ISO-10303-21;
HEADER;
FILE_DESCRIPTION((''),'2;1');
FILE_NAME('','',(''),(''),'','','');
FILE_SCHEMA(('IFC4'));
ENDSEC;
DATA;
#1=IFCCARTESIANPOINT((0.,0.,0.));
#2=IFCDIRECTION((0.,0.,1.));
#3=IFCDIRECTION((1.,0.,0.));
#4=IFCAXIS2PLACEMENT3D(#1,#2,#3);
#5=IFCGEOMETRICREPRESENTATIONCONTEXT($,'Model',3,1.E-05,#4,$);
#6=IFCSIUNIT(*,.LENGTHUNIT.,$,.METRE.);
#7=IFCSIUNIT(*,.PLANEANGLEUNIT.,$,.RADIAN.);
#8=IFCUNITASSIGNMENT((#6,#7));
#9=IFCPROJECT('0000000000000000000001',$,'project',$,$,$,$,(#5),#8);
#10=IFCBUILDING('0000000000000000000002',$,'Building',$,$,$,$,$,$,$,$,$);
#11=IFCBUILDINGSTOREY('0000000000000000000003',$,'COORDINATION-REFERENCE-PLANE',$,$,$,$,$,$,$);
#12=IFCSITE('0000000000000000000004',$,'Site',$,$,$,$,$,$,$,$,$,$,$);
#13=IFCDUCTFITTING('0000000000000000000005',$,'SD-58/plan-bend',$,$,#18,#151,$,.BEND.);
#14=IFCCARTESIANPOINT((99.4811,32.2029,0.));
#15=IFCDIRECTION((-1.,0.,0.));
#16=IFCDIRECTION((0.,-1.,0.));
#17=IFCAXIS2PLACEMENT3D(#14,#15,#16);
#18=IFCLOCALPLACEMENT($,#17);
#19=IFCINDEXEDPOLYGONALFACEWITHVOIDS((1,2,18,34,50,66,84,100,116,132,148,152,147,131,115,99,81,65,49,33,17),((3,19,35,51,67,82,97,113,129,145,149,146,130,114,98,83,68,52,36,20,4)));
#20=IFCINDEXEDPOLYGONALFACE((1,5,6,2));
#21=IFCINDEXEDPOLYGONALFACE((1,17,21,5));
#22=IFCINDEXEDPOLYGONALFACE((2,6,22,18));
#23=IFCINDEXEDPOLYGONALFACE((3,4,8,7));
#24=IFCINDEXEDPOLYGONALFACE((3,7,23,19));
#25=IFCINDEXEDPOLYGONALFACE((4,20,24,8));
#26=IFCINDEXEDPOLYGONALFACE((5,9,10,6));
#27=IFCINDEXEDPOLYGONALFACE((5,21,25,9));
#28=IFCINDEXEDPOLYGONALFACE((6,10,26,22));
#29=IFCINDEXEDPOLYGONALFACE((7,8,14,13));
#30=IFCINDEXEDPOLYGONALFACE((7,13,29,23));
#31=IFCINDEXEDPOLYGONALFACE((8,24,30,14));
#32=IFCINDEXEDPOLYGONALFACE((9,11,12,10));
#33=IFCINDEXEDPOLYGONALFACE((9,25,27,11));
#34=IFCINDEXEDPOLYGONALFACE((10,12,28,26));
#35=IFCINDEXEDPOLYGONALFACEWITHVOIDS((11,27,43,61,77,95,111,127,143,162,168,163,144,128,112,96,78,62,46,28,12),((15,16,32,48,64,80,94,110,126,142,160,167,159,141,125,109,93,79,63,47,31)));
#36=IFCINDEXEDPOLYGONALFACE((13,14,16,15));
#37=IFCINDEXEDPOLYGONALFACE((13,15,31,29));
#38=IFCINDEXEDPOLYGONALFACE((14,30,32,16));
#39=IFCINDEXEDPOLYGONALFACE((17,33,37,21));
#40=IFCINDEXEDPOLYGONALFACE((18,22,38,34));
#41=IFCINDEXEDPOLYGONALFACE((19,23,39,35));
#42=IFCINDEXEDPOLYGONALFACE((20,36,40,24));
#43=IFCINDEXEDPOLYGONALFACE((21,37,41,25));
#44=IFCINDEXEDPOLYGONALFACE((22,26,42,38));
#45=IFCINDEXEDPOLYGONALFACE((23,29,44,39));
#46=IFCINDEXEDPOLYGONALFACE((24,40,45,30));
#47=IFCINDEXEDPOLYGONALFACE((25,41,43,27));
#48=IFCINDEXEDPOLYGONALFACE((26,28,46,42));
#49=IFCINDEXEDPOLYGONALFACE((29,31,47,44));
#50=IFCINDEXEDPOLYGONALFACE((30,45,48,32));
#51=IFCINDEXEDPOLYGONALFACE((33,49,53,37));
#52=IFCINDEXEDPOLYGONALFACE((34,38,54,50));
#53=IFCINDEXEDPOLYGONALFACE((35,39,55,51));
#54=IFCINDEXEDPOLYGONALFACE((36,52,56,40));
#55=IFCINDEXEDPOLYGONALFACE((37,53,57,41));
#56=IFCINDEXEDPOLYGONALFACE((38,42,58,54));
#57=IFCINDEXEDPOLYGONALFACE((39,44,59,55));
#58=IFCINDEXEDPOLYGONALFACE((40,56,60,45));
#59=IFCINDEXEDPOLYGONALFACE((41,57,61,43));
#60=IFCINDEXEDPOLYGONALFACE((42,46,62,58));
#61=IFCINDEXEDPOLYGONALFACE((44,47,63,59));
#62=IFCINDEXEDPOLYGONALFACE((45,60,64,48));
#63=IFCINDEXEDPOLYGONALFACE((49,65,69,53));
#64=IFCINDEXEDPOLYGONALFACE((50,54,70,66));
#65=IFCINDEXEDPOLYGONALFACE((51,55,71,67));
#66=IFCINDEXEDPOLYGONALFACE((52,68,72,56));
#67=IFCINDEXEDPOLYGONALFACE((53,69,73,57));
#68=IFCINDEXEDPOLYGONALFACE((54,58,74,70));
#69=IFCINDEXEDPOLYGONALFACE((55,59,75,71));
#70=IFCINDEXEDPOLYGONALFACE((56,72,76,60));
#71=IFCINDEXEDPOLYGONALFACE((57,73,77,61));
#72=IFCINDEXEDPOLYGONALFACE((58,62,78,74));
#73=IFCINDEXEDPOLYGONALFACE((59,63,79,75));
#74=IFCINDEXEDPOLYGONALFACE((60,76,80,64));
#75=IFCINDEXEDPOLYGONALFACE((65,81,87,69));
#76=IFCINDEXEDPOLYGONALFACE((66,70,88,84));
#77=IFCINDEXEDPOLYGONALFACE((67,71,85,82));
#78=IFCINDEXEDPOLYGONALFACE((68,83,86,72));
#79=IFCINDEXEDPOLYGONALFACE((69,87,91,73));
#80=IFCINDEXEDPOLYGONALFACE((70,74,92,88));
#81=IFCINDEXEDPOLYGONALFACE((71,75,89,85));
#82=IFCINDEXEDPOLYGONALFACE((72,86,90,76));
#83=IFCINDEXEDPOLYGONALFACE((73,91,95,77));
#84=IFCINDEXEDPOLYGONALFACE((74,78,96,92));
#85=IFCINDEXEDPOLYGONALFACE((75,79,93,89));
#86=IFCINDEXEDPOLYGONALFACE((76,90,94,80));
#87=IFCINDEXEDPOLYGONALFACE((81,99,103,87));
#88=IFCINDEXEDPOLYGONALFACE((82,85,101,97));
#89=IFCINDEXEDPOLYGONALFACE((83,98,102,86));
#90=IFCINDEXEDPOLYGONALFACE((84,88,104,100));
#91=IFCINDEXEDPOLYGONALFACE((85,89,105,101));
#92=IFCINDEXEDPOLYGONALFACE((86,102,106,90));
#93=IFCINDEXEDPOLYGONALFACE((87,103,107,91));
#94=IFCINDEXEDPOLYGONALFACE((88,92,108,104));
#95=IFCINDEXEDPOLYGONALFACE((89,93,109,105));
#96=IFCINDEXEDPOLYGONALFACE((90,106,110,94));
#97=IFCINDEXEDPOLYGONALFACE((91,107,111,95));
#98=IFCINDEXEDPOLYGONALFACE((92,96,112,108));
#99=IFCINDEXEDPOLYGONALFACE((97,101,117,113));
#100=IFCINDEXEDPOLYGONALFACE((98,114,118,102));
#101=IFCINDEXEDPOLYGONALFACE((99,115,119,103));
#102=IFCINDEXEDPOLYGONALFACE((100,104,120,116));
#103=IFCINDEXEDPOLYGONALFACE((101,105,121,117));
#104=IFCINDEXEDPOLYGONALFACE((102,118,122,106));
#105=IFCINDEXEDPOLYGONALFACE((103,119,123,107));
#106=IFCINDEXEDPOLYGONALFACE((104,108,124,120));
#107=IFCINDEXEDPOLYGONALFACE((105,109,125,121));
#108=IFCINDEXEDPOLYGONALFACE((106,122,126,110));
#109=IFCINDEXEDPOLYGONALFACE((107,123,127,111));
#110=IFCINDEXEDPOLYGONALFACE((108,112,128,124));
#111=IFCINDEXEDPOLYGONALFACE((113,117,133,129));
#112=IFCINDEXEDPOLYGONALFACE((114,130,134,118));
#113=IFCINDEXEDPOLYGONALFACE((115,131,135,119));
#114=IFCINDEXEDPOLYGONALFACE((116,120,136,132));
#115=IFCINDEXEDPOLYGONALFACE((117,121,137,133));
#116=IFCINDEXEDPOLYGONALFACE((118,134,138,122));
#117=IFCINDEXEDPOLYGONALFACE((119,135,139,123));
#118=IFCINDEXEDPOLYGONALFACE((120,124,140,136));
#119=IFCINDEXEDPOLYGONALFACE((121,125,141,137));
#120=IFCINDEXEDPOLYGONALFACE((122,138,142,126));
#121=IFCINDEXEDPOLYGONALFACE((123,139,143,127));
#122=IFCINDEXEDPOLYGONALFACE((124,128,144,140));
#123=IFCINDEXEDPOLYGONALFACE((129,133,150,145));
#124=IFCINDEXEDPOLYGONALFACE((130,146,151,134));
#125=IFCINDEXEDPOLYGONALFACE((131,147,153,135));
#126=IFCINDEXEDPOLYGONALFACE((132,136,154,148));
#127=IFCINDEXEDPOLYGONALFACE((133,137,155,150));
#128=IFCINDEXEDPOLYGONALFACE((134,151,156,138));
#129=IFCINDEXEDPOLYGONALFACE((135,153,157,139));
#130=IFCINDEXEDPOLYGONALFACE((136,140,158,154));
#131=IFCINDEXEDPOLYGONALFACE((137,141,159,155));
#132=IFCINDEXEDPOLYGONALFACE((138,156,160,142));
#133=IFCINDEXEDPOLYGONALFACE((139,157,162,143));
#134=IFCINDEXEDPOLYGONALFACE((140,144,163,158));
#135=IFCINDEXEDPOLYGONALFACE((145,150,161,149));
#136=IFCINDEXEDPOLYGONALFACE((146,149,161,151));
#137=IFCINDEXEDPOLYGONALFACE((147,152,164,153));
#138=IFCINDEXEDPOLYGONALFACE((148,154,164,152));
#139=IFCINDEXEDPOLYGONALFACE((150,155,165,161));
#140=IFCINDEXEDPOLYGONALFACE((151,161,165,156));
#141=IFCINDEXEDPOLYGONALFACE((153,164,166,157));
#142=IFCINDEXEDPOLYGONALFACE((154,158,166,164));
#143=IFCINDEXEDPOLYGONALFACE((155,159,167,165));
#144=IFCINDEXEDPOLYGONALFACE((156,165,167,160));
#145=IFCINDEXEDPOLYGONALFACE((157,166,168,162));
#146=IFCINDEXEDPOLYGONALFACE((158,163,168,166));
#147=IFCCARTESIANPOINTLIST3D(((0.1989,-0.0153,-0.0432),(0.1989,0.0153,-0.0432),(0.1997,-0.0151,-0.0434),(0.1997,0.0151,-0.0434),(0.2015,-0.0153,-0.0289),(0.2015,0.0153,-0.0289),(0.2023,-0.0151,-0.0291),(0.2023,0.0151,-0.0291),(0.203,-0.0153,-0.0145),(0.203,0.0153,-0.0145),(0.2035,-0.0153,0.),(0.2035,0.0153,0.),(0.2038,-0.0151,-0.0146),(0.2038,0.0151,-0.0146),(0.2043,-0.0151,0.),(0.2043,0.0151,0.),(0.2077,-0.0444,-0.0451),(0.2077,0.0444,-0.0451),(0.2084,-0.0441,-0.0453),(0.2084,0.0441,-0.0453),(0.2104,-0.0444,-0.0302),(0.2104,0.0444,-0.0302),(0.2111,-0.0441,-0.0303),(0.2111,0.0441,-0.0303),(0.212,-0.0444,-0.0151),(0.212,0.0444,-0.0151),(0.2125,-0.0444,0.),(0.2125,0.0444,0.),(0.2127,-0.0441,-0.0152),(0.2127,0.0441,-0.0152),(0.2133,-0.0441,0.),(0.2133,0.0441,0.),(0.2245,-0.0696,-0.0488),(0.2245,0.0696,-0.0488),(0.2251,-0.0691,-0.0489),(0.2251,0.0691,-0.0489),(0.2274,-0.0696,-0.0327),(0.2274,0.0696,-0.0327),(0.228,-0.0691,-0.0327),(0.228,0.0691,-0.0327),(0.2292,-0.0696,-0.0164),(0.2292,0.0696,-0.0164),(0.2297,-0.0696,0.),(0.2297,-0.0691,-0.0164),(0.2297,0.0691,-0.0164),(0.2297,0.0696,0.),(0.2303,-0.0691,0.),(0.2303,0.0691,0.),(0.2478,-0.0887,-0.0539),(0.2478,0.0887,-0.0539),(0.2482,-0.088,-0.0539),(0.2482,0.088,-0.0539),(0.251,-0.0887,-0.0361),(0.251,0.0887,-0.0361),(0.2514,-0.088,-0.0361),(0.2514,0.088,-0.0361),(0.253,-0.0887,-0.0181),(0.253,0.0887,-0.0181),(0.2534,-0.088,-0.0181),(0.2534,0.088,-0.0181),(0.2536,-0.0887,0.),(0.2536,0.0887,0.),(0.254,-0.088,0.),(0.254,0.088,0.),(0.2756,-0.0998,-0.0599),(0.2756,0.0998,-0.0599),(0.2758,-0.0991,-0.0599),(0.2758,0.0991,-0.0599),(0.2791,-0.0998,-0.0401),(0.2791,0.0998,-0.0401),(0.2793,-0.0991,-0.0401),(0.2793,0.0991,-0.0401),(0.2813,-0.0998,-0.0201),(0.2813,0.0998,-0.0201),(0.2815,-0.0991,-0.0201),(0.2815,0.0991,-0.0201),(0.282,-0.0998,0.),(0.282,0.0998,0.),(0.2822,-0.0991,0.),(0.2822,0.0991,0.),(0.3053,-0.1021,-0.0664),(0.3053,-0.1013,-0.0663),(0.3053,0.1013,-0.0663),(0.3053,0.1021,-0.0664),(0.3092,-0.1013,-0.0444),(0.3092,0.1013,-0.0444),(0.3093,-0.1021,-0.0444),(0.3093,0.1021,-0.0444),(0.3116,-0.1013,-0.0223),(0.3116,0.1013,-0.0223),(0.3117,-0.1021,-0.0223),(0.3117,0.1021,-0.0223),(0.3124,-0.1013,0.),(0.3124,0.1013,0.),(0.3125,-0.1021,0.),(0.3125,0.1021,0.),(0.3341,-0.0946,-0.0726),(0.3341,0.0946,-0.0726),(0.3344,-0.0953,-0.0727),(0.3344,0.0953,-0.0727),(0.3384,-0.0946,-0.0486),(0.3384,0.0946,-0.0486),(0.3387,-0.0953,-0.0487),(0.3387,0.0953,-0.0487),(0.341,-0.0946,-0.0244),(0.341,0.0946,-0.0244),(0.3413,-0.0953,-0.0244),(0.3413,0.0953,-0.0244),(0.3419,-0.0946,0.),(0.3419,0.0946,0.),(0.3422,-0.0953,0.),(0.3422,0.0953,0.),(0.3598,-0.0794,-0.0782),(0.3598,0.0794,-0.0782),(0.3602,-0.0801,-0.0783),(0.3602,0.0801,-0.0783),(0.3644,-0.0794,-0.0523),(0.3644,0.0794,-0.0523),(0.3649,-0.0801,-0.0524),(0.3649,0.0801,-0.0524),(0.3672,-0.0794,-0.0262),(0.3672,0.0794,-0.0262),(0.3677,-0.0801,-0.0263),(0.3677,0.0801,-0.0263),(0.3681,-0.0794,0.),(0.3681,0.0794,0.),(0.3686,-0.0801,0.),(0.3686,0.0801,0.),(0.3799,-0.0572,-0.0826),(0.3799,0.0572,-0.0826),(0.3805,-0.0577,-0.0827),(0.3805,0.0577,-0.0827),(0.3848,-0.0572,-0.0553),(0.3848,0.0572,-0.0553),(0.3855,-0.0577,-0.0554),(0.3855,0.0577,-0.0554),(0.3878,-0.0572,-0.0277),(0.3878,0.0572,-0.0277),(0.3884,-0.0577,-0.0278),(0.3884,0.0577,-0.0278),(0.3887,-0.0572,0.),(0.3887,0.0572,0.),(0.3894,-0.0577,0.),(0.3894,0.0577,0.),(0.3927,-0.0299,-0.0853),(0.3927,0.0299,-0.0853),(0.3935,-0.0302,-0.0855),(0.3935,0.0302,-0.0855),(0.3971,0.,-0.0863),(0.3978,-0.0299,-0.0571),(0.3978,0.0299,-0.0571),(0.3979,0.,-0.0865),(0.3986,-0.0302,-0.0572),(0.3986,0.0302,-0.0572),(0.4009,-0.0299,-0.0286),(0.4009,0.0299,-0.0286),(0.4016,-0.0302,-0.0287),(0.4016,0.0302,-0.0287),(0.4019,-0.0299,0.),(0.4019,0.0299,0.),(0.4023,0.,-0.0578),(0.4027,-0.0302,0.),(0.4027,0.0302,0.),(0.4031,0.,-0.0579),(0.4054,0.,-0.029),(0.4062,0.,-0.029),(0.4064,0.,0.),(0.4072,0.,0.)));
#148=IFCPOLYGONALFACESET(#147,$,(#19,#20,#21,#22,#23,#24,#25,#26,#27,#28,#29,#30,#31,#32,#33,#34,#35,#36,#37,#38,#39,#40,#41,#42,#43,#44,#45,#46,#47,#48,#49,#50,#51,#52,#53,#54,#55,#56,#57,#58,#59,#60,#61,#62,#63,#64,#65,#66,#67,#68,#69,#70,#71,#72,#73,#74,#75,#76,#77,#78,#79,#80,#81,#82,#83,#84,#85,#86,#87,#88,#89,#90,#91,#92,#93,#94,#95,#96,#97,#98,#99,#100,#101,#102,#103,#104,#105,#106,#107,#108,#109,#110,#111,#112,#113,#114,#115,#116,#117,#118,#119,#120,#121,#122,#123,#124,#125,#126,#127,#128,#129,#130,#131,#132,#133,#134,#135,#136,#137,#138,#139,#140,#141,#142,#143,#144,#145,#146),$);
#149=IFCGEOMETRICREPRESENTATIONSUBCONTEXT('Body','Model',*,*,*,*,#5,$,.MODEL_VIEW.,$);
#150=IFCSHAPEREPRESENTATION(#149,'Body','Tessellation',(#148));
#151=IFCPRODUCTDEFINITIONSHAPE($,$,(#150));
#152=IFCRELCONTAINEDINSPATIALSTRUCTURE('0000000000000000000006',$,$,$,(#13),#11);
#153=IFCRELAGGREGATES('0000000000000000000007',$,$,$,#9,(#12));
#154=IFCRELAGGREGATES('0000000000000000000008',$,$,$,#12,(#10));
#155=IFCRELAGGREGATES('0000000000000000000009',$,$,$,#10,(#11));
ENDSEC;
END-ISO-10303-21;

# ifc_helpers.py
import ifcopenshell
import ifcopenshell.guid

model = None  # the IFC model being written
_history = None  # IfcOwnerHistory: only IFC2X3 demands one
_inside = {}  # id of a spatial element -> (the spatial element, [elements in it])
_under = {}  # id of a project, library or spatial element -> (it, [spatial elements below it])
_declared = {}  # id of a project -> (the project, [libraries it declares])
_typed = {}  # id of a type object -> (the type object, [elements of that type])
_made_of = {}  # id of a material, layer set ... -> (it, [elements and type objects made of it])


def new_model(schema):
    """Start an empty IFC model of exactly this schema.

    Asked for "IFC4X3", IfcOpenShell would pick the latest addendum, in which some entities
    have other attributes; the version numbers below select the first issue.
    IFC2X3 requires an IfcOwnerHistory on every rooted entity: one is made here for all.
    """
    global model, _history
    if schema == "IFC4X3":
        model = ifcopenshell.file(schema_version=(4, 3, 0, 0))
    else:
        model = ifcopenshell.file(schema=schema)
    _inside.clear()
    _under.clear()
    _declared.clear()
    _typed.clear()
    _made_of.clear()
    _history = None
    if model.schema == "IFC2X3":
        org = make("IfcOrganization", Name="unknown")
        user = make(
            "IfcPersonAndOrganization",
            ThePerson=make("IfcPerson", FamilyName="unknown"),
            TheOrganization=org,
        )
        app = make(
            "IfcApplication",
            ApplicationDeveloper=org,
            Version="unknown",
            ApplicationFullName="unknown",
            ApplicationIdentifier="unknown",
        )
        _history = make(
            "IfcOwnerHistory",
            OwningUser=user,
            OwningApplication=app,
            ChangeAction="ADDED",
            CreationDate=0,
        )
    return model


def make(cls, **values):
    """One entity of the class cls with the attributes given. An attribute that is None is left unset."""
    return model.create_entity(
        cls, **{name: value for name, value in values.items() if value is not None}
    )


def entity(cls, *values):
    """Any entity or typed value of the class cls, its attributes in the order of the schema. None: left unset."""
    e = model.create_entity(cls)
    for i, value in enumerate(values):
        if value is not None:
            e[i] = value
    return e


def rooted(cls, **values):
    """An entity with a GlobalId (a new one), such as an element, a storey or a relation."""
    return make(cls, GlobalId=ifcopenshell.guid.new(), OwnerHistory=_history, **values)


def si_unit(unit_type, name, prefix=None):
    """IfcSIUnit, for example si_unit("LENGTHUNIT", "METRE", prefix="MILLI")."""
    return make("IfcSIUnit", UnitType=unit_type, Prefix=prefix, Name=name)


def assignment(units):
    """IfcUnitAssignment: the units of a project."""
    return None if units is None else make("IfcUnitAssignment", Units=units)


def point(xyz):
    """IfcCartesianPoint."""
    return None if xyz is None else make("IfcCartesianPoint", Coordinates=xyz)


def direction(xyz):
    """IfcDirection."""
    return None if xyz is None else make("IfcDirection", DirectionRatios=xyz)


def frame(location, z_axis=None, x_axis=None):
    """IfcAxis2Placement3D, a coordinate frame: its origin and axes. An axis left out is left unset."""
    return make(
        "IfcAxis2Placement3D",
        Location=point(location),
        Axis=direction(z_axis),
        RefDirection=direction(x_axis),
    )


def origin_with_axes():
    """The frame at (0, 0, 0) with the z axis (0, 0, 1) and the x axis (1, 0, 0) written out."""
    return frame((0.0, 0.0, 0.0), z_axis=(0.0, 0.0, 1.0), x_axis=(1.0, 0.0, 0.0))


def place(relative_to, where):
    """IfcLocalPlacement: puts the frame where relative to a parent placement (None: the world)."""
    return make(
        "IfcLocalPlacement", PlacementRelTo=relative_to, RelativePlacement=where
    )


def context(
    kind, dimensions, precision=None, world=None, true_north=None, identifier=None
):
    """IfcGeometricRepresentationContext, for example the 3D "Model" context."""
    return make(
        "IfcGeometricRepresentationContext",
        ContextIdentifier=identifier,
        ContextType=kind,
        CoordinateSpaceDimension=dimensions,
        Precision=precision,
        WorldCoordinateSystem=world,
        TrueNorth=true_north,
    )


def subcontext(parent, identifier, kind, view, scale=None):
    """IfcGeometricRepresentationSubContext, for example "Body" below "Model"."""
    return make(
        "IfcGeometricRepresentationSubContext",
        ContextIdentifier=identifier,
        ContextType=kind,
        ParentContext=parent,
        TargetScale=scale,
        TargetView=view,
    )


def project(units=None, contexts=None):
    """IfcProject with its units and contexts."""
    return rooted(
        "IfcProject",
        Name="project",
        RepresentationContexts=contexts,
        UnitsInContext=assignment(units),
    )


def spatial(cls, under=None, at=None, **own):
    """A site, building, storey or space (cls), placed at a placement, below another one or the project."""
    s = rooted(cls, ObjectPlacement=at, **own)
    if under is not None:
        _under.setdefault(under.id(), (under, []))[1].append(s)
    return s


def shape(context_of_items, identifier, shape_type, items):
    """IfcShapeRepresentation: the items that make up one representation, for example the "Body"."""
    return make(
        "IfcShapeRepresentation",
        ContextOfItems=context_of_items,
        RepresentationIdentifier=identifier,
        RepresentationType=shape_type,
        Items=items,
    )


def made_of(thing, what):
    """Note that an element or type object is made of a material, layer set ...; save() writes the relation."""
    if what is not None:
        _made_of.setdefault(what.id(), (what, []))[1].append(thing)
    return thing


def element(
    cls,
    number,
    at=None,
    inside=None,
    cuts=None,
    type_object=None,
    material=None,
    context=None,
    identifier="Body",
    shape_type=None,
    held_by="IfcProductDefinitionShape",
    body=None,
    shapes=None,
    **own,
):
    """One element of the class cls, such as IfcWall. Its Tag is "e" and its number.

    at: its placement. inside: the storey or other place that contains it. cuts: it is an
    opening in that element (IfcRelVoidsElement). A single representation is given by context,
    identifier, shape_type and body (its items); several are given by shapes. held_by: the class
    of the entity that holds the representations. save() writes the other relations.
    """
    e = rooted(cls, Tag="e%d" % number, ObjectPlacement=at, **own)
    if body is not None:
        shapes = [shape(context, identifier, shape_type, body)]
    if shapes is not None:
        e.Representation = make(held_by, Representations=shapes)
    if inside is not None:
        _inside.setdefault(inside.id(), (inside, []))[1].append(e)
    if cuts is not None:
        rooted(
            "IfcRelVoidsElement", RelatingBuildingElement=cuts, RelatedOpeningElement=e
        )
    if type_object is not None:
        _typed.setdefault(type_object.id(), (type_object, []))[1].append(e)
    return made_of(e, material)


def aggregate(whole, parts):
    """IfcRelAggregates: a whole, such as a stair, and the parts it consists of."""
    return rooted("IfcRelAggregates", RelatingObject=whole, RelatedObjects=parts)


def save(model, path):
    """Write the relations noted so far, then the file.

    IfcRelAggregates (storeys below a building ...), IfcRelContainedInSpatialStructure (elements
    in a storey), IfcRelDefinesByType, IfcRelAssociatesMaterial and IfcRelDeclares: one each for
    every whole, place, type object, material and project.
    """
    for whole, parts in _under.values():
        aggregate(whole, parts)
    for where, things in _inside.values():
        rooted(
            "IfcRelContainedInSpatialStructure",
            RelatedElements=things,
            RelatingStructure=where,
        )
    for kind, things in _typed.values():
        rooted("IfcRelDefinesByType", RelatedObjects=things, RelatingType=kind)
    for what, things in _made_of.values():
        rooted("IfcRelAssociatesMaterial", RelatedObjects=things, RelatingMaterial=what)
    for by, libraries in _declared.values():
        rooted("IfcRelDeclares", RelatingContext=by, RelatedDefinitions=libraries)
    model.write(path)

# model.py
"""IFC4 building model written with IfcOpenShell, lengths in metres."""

from ifc_helpers import new_model, entity, si_unit, frame, origin_with_axes, place, context, subcontext, project, spatial, element, save


model = new_model("IFC4")

# Units and contexts
model_context = context("Model", 3, precision=1e-05, world=origin_with_axes())
body_context_1 = subcontext(model_context, "Body", "Model", "MODEL_VIEW")
ifc_project = project(units=[si_unit("LENGTHUNIT", "METRE"), si_unit("PLANEANGLEUNIT", "RADIAN")], contexts=[model_context])

# Site, building, storey
site = spatial("IfcSite", under=ifc_project, Name="Site")
building = spatial("IfcBuilding", under=site, Name="Building")
storey = spatial("IfcBuildingStorey", under=building, Name="COORDINATION-REFERENCE-PLANE")

# Duct fitting
duct_fitting_1_placement = place(None, frame((99.4811, 32.2029, 0.0), z_axis=(-1.0, 0.0, 0.0), x_axis=(0.0, -1.0, 0.0)))
element("IfcDuctFitting", 1, at=duct_fitting_1_placement, inside=storey, Name="SD-58/plan-bend", PredefinedType="BEND", context=body_context_1, shape_type="SweptSolid", body=[
    entity("IfcRevolvedAreaSolid", entity("IfcCircleHollowProfileDef", "AREA", None, entity("IfcAxis2Placement2D", entity("IfcCartesianPoint", [0.3048, 0.0])), 0.1024, 0.0008), entity("IfcAxis2Placement3D", entity("IfcCartesianPoint", [0.0, 0.0, 0.0]), entity("IfcDirection", [0.0, 0.0, 1.0]), entity("IfcDirection", [1.0, 0.0, 0.0])), entity("IfcAxis1Placement", entity("IfcCartesianPoint", [0.0, 0.0, 0.0]), entity("IfcDirection", [0.0, 1.0, 0.0])), 0.213982),
])

save(model, "model.ifc")
